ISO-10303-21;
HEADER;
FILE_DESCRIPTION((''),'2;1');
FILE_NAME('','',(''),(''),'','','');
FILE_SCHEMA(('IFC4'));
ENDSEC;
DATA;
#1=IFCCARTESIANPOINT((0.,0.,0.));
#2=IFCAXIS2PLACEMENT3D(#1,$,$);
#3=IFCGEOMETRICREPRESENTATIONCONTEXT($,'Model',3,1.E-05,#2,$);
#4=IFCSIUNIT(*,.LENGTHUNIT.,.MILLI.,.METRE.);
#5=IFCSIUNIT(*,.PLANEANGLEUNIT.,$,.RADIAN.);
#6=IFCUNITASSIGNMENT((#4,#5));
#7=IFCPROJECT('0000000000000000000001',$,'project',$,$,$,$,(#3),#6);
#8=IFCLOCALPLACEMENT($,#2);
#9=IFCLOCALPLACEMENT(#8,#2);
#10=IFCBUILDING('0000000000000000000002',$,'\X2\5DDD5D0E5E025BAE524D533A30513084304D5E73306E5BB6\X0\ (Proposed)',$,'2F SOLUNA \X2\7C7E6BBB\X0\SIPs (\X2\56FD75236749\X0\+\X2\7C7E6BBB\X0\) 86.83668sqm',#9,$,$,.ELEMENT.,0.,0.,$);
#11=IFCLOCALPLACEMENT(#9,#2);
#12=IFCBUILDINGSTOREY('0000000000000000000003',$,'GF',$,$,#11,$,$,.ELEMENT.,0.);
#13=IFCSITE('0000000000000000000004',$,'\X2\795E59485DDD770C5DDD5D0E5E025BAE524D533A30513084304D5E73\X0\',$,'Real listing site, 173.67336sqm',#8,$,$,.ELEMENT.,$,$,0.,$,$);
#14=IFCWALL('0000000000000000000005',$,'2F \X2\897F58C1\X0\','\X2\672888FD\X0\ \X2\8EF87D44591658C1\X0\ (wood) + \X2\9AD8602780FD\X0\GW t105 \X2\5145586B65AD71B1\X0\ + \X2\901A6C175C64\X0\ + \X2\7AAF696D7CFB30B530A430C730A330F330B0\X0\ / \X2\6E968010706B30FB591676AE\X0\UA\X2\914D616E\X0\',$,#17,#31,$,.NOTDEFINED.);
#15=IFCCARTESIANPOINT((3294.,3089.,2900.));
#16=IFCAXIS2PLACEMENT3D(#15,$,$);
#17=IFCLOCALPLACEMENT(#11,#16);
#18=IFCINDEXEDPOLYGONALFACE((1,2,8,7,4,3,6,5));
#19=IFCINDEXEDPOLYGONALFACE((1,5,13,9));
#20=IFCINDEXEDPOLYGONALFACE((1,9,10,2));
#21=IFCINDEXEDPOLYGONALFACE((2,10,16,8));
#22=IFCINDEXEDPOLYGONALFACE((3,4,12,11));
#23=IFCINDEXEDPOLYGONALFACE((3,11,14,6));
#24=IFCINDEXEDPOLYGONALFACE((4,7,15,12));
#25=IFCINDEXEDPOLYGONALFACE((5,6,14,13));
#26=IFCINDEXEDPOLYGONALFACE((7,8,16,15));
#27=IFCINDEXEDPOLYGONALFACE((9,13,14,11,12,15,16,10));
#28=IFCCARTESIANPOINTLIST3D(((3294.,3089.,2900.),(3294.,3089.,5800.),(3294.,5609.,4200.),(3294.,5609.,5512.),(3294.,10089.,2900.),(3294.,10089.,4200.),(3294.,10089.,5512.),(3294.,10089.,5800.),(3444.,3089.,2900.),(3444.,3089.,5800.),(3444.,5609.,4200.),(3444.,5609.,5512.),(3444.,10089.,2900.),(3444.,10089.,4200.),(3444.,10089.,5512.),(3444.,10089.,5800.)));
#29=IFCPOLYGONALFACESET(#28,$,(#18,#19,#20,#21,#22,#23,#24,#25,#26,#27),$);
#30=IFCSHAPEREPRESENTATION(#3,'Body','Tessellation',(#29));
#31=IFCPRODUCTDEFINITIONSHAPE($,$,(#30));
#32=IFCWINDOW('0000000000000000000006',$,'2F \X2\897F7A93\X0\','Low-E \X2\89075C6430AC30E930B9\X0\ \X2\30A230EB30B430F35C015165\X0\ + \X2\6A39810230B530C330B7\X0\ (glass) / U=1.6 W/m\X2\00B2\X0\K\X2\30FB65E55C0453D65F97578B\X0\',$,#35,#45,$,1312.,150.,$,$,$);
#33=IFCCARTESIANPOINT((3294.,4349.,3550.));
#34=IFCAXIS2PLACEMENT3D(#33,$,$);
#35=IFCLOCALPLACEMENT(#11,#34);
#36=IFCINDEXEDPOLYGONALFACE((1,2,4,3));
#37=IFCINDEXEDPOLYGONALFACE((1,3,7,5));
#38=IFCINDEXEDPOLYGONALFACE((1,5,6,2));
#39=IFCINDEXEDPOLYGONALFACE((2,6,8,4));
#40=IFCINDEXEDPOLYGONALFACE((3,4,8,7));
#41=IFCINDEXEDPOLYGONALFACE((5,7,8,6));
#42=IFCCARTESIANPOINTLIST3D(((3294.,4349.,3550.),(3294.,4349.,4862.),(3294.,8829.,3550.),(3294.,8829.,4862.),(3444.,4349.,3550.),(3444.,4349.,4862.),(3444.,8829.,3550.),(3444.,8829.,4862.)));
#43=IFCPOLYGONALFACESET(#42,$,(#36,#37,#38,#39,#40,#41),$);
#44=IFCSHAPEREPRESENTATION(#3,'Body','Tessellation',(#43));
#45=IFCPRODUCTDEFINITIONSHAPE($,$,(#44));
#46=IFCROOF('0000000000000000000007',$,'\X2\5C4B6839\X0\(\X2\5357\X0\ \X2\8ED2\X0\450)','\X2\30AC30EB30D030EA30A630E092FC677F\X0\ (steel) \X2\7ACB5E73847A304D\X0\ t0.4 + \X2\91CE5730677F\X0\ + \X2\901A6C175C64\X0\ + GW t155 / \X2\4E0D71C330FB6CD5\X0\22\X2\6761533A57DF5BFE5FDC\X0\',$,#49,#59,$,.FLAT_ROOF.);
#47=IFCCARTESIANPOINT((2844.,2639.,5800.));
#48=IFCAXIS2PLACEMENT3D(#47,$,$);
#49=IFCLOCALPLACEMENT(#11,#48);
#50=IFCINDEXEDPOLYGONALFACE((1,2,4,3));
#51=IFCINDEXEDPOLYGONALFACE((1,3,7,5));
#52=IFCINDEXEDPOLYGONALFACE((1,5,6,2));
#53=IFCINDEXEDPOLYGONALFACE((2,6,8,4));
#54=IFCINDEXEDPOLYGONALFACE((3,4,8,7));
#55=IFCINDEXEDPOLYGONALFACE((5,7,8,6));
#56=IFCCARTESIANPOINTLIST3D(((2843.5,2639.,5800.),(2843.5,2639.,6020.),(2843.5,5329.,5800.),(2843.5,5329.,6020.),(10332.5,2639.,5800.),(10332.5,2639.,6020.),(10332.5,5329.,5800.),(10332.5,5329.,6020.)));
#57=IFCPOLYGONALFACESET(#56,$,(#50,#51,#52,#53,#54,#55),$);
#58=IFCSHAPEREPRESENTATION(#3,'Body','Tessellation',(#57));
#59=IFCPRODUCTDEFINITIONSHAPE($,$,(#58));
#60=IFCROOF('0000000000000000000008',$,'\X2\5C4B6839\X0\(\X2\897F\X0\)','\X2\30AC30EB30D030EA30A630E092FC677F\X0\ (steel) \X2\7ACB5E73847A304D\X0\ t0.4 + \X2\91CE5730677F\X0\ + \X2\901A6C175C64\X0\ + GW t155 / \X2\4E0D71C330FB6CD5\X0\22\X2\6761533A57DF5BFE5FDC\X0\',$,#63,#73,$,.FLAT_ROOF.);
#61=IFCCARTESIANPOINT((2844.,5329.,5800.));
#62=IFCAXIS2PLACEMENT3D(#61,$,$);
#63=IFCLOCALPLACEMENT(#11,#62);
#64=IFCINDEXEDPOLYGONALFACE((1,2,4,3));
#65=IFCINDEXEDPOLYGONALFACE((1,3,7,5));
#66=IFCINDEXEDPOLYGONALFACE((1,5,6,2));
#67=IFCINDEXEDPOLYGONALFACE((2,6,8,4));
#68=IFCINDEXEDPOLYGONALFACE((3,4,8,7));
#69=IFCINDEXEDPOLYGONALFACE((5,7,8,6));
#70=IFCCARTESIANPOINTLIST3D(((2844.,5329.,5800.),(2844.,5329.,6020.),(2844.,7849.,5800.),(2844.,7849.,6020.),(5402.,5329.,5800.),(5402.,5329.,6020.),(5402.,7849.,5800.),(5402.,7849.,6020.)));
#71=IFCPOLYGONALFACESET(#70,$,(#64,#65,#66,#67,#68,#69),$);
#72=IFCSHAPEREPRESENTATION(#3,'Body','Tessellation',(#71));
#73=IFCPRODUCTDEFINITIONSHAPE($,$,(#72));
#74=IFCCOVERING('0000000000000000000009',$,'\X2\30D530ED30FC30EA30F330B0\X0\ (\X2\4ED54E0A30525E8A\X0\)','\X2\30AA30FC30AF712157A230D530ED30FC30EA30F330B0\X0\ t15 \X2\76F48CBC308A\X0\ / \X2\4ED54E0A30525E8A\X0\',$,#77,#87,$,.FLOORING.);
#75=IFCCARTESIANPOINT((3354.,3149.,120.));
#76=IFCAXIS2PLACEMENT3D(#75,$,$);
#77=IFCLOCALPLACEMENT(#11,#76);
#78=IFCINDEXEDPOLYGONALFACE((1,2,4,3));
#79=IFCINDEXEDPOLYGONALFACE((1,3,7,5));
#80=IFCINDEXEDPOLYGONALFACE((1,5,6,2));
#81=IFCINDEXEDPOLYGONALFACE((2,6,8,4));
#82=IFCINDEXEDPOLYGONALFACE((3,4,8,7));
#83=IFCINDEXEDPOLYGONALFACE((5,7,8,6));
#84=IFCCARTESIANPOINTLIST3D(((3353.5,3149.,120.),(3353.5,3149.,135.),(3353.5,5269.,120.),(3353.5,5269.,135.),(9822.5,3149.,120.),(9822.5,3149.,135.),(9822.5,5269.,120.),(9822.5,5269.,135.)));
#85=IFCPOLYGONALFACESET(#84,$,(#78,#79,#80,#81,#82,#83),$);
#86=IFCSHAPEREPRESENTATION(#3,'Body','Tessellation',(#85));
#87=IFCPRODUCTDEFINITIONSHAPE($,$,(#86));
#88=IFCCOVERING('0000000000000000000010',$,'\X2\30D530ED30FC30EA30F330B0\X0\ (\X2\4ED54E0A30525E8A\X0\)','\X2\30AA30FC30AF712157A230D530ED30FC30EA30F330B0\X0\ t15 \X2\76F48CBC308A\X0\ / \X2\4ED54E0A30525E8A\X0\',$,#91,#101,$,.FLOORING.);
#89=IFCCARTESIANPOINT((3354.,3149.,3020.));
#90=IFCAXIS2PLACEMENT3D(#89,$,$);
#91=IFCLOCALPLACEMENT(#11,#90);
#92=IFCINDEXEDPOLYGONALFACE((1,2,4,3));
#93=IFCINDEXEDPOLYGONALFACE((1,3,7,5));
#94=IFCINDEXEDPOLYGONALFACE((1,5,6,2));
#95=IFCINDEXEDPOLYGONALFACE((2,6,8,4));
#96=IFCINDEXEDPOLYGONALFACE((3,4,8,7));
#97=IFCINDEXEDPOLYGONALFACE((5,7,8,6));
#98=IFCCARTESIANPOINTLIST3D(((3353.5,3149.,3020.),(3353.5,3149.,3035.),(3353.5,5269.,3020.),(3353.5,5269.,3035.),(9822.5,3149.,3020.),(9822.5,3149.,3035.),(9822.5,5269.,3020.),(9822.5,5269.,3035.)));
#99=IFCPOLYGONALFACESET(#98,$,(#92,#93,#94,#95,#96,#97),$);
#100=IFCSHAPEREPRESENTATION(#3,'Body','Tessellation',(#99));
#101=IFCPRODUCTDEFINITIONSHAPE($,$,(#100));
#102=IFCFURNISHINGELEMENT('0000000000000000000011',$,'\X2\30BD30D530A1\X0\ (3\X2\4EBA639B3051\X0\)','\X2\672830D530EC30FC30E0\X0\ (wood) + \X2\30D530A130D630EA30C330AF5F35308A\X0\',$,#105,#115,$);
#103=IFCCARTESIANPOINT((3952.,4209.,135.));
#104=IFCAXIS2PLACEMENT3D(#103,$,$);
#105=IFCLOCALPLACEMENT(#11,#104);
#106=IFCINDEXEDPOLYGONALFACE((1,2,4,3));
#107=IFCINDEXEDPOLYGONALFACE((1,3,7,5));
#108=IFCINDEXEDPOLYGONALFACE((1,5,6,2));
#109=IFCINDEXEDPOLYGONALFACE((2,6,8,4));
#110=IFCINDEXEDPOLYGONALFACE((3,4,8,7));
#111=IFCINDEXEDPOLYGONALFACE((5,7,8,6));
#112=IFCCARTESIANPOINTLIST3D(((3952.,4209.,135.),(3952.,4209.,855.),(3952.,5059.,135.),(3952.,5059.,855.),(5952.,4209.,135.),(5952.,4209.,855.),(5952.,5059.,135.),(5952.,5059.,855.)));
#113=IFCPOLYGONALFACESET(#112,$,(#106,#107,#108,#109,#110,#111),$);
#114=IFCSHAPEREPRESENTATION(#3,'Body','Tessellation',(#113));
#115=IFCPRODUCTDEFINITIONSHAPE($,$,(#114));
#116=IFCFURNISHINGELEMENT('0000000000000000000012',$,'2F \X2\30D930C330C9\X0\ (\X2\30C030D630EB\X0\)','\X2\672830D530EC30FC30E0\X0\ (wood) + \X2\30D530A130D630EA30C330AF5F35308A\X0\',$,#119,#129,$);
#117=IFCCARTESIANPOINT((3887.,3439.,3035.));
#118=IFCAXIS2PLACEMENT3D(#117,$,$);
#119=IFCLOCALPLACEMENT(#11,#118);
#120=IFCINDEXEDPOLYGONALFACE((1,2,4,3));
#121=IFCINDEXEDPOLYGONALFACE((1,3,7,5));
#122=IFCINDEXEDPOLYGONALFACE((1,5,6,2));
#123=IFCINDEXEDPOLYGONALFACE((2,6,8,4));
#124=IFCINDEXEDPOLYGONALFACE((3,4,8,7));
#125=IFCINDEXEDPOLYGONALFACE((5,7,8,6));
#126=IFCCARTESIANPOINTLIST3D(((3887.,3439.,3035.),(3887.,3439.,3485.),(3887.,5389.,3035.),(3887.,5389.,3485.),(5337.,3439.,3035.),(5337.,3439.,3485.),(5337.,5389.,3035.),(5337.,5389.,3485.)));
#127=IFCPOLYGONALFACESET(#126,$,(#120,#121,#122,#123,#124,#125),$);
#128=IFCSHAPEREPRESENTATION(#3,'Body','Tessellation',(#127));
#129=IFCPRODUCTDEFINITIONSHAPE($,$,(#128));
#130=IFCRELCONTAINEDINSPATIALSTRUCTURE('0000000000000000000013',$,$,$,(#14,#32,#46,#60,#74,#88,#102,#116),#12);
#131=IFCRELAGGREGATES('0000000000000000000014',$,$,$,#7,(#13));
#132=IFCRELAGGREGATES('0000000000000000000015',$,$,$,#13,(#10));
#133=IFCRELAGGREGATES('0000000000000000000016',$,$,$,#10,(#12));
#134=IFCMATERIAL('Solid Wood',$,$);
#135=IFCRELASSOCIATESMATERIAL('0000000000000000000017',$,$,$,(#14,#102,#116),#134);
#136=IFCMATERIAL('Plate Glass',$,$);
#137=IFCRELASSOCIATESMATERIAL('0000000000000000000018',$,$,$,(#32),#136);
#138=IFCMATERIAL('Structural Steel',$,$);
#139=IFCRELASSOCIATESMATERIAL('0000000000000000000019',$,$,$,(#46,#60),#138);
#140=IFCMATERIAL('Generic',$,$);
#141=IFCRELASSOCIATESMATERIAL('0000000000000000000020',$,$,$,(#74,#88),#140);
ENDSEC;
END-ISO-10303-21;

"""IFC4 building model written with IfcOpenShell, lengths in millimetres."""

from ifc_helpers import new_model, si_unit, frame, frame_2d, origin, place, context, project, spatial, rectangle, extrude, material, element, fill, save


model = new_model("IFC4")

# Units and contexts
model_context = context("Model", 3, precision=1e-05, world=origin())
ifc_project = project(units=[si_unit("LENGTHUNIT", "METRE", prefix="MILLI"), si_unit("PLANEANGLEUNIT", "RADIAN")], contexts=[model_context])

# Site, building, storey
site_placement = place(None, origin())
site = spatial("IfcSite", under=ifc_project, at=site_placement, Name="神奈川県川崎市宮前区けやき平", ObjectType="Real listing site, 173.67336sqm", CompositionType="ELEMENT", RefElevation=0.0)
building_placement = place(site_placement, origin())
building = spatial("IfcBuilding", under=site, at=building_placement, Name="川崎市宮前区けやき平の家 (Proposed)", ObjectType="2F SOLUNA 籾殻SIPs (国産杉+籾殻) 86.83668sqm", CompositionType="ELEMENT", ElevationOfRefHeight=0.0, ElevationOfTerrain=0.0)
storey_placement = place(building_placement, origin())
storey = spatial("IfcBuildingStorey", under=building, at=storey_placement, Name="GF", CompositionType="ELEMENT", Elevation=0.0)

# Shared definitions
ifc_material_1 = material(Name="Solid Wood")

# Shared definitions
ifc_material_2 = material(Name="Plate Glass")

# Wall, opening, window
wall_1_placement = place(storey_placement, frame((3294.0, 3089.0, 2900.0)))
wall_1 = element("IfcWall", 1, at=wall_1_placement, inside=storey, material=ifc_material_1, Name="2F 西壁", Description="木製 軸組外壁 (wood) + 高性能GW t105 充填断熱 + 通気層 + 窯業系サイディング / 準耐火・外皮UA配慮", PredefinedType="NOTDEFINED", context=model_context, shape_type="SweptSolid", body=[
    extrude(rectangle(XDim=150.0, YDim=7000.0, at=frame_2d((75.0, 3500.0))), frame((3294.0, 3089.0, 2900.0)), (0.0, 0.0, 1.0), 2900.0),
])
opening_1_placement = place(storey_placement, frame((3294.0, 4349.0, 3550.0)))
opening_1 = element("IfcOpeningElement", 2, at=opening_1_placement, cuts=wall_1, PredefinedType="NOTDEFINED", context=model_context, shape_type="SweptSolid", body=[
    extrude(rectangle(XDim=150.0, YDim=4480.0, at=frame_2d((75.0, 2240.0))), frame((3294.0, 4349.0, 3550.0)), (0.0, 0.0, 1.0), 1312.0),
])
window_1_placement = place(storey_placement, frame((3294.0, 4349.0, 3550.0)))
window_1 = element("IfcWindow", 3, at=window_1_placement, inside=storey, material=ifc_material_2, Name="2F 西窓", Description="Low-E 複層ガラス アルゴン封入 + 樹脂サッシ (glass) / U=1.6 W/m²K・日射取得型", OverallHeight=1312.0, OverallWidth=150.0, context=model_context, shape_type="SweptSolid", body=[
    extrude(rectangle(XDim=150.0, YDim=4480.0, at=frame_2d((75.0, 2240.0))), frame((3294.0, 4349.0, 3550.0)), (0.0, 0.0, 1.0), 1312.0),
])
fill(opening_1, window_1)

# Roofs
ifc_material_3 = material(Name="Structural Steel")
roof_1_placement = place(storey_placement, frame((2844.0, 2639.0, 5800.0)))
element("IfcRoof", 4, at=roof_1_placement, inside=storey, material=ifc_material_3, Name="屋根(南 軒450)", Description="ガルバリウム鋼板 (steel) 立平葺き t0.4 + 野地板 + 通気層 + GW t155 / 不燃・法22条区域対応", PredefinedType="FLAT_ROOF", context=model_context, shape_type="SweptSolid", body=[
    extrude(rectangle(XDim=7489.0, YDim=2690.0, at=frame_2d((3744.0, 1345.0))), frame((2844.0, 2639.0, 5800.0)), (0.0, 0.0, 1.0), 220.0),
])
roof_2_placement = place(storey_placement, frame((2844.0, 5329.0, 5800.0)))
element("IfcRoof", 5, at=roof_2_placement, inside=storey, material=ifc_material_3, Name="屋根(西)", Description="ガルバリウム鋼板 (steel) 立平葺き t0.4 + 野地板 + 通気層 + GW t155 / 不燃・法22条区域対応", PredefinedType="FLAT_ROOF", context=model_context, shape_type="SweptSolid", body=[
    extrude(rectangle(XDim=2558.0, YDim=2520.0, at=frame_2d((1279.0, 1260.0))), frame((2844.0, 5329.0, 5800.0)), (0.0, 0.0, 1.0), 220.0),
])

# Coverings
ifc_material_4 = material(Name="Generic")
covering_1_placement = place(storey_placement, frame((3354.0, 3149.0, 120.0)))
element("IfcCovering", 6, at=covering_1_placement, inside=storey, material=ifc_material_4, Name="フローリング (仕上げ床)", Description="オーク無垢フローリング t15 直貼り / 仕上げ床", PredefinedType="FLOORING", context=model_context, shape_type="SweptSolid", body=[
    extrude(rectangle(XDim=6469.0, YDim=2120.0, at=frame_2d((3234.0, 1060.0))), frame((3354.0, 3149.0, 120.0)), (0.0, 0.0, 1.0), 15.0),
])
covering_2_placement = place(storey_placement, frame((3354.0, 3149.0, 3020.0)))
element("IfcCovering", 7, at=covering_2_placement, inside=storey, material=ifc_material_4, Name="フローリング (仕上げ床)", Description="オーク無垢フローリング t15 直貼り / 仕上げ床", PredefinedType="FLOORING", context=model_context, shape_type="SweptSolid", body=[
    extrude(rectangle(XDim=6469.0, YDim=2120.0, at=frame_2d((3234.0, 1060.0))), frame((3354.0, 3149.0, 3020.0)), (0.0, 0.0, 1.0), 15.0),
])

# Furnishing elements
furnishing_1_placement = place(storey_placement, frame((3952.0, 4209.0, 135.0)))
element("IfcFurnishingElement", 8, at=furnishing_1_placement, inside=storey, material=ifc_material_1, Name="ソファ (3人掛け)", Description="木フレーム (wood) + ファブリック張り", context=model_context, shape_type="SweptSolid", body=[
    extrude(rectangle(XDim=2000.0, YDim=850.0, at=frame_2d((1000.0, 425.0))), frame((3952.0, 4209.0, 135.0)), (0.0, 0.0, 1.0), 720.0),
])
furnishing_2_placement = place(storey_placement, frame((3887.0, 3439.0, 3035.0)))
element("IfcFurnishingElement", 9, at=furnishing_2_placement, inside=storey, material=ifc_material_1, Name="2F ベッド (ダブル)", Description="木フレーム (wood) + ファブリック張り", context=model_context, shape_type="SweptSolid", body=[
    extrude(rectangle(XDim=1450.0, YDim=1950.0, at=frame_2d((725.0, 975.0))), frame((3887.0, 3439.0, 3035.0)), (0.0, 0.0, 1.0), 450.0),
])

save(model, "model.ifc")
